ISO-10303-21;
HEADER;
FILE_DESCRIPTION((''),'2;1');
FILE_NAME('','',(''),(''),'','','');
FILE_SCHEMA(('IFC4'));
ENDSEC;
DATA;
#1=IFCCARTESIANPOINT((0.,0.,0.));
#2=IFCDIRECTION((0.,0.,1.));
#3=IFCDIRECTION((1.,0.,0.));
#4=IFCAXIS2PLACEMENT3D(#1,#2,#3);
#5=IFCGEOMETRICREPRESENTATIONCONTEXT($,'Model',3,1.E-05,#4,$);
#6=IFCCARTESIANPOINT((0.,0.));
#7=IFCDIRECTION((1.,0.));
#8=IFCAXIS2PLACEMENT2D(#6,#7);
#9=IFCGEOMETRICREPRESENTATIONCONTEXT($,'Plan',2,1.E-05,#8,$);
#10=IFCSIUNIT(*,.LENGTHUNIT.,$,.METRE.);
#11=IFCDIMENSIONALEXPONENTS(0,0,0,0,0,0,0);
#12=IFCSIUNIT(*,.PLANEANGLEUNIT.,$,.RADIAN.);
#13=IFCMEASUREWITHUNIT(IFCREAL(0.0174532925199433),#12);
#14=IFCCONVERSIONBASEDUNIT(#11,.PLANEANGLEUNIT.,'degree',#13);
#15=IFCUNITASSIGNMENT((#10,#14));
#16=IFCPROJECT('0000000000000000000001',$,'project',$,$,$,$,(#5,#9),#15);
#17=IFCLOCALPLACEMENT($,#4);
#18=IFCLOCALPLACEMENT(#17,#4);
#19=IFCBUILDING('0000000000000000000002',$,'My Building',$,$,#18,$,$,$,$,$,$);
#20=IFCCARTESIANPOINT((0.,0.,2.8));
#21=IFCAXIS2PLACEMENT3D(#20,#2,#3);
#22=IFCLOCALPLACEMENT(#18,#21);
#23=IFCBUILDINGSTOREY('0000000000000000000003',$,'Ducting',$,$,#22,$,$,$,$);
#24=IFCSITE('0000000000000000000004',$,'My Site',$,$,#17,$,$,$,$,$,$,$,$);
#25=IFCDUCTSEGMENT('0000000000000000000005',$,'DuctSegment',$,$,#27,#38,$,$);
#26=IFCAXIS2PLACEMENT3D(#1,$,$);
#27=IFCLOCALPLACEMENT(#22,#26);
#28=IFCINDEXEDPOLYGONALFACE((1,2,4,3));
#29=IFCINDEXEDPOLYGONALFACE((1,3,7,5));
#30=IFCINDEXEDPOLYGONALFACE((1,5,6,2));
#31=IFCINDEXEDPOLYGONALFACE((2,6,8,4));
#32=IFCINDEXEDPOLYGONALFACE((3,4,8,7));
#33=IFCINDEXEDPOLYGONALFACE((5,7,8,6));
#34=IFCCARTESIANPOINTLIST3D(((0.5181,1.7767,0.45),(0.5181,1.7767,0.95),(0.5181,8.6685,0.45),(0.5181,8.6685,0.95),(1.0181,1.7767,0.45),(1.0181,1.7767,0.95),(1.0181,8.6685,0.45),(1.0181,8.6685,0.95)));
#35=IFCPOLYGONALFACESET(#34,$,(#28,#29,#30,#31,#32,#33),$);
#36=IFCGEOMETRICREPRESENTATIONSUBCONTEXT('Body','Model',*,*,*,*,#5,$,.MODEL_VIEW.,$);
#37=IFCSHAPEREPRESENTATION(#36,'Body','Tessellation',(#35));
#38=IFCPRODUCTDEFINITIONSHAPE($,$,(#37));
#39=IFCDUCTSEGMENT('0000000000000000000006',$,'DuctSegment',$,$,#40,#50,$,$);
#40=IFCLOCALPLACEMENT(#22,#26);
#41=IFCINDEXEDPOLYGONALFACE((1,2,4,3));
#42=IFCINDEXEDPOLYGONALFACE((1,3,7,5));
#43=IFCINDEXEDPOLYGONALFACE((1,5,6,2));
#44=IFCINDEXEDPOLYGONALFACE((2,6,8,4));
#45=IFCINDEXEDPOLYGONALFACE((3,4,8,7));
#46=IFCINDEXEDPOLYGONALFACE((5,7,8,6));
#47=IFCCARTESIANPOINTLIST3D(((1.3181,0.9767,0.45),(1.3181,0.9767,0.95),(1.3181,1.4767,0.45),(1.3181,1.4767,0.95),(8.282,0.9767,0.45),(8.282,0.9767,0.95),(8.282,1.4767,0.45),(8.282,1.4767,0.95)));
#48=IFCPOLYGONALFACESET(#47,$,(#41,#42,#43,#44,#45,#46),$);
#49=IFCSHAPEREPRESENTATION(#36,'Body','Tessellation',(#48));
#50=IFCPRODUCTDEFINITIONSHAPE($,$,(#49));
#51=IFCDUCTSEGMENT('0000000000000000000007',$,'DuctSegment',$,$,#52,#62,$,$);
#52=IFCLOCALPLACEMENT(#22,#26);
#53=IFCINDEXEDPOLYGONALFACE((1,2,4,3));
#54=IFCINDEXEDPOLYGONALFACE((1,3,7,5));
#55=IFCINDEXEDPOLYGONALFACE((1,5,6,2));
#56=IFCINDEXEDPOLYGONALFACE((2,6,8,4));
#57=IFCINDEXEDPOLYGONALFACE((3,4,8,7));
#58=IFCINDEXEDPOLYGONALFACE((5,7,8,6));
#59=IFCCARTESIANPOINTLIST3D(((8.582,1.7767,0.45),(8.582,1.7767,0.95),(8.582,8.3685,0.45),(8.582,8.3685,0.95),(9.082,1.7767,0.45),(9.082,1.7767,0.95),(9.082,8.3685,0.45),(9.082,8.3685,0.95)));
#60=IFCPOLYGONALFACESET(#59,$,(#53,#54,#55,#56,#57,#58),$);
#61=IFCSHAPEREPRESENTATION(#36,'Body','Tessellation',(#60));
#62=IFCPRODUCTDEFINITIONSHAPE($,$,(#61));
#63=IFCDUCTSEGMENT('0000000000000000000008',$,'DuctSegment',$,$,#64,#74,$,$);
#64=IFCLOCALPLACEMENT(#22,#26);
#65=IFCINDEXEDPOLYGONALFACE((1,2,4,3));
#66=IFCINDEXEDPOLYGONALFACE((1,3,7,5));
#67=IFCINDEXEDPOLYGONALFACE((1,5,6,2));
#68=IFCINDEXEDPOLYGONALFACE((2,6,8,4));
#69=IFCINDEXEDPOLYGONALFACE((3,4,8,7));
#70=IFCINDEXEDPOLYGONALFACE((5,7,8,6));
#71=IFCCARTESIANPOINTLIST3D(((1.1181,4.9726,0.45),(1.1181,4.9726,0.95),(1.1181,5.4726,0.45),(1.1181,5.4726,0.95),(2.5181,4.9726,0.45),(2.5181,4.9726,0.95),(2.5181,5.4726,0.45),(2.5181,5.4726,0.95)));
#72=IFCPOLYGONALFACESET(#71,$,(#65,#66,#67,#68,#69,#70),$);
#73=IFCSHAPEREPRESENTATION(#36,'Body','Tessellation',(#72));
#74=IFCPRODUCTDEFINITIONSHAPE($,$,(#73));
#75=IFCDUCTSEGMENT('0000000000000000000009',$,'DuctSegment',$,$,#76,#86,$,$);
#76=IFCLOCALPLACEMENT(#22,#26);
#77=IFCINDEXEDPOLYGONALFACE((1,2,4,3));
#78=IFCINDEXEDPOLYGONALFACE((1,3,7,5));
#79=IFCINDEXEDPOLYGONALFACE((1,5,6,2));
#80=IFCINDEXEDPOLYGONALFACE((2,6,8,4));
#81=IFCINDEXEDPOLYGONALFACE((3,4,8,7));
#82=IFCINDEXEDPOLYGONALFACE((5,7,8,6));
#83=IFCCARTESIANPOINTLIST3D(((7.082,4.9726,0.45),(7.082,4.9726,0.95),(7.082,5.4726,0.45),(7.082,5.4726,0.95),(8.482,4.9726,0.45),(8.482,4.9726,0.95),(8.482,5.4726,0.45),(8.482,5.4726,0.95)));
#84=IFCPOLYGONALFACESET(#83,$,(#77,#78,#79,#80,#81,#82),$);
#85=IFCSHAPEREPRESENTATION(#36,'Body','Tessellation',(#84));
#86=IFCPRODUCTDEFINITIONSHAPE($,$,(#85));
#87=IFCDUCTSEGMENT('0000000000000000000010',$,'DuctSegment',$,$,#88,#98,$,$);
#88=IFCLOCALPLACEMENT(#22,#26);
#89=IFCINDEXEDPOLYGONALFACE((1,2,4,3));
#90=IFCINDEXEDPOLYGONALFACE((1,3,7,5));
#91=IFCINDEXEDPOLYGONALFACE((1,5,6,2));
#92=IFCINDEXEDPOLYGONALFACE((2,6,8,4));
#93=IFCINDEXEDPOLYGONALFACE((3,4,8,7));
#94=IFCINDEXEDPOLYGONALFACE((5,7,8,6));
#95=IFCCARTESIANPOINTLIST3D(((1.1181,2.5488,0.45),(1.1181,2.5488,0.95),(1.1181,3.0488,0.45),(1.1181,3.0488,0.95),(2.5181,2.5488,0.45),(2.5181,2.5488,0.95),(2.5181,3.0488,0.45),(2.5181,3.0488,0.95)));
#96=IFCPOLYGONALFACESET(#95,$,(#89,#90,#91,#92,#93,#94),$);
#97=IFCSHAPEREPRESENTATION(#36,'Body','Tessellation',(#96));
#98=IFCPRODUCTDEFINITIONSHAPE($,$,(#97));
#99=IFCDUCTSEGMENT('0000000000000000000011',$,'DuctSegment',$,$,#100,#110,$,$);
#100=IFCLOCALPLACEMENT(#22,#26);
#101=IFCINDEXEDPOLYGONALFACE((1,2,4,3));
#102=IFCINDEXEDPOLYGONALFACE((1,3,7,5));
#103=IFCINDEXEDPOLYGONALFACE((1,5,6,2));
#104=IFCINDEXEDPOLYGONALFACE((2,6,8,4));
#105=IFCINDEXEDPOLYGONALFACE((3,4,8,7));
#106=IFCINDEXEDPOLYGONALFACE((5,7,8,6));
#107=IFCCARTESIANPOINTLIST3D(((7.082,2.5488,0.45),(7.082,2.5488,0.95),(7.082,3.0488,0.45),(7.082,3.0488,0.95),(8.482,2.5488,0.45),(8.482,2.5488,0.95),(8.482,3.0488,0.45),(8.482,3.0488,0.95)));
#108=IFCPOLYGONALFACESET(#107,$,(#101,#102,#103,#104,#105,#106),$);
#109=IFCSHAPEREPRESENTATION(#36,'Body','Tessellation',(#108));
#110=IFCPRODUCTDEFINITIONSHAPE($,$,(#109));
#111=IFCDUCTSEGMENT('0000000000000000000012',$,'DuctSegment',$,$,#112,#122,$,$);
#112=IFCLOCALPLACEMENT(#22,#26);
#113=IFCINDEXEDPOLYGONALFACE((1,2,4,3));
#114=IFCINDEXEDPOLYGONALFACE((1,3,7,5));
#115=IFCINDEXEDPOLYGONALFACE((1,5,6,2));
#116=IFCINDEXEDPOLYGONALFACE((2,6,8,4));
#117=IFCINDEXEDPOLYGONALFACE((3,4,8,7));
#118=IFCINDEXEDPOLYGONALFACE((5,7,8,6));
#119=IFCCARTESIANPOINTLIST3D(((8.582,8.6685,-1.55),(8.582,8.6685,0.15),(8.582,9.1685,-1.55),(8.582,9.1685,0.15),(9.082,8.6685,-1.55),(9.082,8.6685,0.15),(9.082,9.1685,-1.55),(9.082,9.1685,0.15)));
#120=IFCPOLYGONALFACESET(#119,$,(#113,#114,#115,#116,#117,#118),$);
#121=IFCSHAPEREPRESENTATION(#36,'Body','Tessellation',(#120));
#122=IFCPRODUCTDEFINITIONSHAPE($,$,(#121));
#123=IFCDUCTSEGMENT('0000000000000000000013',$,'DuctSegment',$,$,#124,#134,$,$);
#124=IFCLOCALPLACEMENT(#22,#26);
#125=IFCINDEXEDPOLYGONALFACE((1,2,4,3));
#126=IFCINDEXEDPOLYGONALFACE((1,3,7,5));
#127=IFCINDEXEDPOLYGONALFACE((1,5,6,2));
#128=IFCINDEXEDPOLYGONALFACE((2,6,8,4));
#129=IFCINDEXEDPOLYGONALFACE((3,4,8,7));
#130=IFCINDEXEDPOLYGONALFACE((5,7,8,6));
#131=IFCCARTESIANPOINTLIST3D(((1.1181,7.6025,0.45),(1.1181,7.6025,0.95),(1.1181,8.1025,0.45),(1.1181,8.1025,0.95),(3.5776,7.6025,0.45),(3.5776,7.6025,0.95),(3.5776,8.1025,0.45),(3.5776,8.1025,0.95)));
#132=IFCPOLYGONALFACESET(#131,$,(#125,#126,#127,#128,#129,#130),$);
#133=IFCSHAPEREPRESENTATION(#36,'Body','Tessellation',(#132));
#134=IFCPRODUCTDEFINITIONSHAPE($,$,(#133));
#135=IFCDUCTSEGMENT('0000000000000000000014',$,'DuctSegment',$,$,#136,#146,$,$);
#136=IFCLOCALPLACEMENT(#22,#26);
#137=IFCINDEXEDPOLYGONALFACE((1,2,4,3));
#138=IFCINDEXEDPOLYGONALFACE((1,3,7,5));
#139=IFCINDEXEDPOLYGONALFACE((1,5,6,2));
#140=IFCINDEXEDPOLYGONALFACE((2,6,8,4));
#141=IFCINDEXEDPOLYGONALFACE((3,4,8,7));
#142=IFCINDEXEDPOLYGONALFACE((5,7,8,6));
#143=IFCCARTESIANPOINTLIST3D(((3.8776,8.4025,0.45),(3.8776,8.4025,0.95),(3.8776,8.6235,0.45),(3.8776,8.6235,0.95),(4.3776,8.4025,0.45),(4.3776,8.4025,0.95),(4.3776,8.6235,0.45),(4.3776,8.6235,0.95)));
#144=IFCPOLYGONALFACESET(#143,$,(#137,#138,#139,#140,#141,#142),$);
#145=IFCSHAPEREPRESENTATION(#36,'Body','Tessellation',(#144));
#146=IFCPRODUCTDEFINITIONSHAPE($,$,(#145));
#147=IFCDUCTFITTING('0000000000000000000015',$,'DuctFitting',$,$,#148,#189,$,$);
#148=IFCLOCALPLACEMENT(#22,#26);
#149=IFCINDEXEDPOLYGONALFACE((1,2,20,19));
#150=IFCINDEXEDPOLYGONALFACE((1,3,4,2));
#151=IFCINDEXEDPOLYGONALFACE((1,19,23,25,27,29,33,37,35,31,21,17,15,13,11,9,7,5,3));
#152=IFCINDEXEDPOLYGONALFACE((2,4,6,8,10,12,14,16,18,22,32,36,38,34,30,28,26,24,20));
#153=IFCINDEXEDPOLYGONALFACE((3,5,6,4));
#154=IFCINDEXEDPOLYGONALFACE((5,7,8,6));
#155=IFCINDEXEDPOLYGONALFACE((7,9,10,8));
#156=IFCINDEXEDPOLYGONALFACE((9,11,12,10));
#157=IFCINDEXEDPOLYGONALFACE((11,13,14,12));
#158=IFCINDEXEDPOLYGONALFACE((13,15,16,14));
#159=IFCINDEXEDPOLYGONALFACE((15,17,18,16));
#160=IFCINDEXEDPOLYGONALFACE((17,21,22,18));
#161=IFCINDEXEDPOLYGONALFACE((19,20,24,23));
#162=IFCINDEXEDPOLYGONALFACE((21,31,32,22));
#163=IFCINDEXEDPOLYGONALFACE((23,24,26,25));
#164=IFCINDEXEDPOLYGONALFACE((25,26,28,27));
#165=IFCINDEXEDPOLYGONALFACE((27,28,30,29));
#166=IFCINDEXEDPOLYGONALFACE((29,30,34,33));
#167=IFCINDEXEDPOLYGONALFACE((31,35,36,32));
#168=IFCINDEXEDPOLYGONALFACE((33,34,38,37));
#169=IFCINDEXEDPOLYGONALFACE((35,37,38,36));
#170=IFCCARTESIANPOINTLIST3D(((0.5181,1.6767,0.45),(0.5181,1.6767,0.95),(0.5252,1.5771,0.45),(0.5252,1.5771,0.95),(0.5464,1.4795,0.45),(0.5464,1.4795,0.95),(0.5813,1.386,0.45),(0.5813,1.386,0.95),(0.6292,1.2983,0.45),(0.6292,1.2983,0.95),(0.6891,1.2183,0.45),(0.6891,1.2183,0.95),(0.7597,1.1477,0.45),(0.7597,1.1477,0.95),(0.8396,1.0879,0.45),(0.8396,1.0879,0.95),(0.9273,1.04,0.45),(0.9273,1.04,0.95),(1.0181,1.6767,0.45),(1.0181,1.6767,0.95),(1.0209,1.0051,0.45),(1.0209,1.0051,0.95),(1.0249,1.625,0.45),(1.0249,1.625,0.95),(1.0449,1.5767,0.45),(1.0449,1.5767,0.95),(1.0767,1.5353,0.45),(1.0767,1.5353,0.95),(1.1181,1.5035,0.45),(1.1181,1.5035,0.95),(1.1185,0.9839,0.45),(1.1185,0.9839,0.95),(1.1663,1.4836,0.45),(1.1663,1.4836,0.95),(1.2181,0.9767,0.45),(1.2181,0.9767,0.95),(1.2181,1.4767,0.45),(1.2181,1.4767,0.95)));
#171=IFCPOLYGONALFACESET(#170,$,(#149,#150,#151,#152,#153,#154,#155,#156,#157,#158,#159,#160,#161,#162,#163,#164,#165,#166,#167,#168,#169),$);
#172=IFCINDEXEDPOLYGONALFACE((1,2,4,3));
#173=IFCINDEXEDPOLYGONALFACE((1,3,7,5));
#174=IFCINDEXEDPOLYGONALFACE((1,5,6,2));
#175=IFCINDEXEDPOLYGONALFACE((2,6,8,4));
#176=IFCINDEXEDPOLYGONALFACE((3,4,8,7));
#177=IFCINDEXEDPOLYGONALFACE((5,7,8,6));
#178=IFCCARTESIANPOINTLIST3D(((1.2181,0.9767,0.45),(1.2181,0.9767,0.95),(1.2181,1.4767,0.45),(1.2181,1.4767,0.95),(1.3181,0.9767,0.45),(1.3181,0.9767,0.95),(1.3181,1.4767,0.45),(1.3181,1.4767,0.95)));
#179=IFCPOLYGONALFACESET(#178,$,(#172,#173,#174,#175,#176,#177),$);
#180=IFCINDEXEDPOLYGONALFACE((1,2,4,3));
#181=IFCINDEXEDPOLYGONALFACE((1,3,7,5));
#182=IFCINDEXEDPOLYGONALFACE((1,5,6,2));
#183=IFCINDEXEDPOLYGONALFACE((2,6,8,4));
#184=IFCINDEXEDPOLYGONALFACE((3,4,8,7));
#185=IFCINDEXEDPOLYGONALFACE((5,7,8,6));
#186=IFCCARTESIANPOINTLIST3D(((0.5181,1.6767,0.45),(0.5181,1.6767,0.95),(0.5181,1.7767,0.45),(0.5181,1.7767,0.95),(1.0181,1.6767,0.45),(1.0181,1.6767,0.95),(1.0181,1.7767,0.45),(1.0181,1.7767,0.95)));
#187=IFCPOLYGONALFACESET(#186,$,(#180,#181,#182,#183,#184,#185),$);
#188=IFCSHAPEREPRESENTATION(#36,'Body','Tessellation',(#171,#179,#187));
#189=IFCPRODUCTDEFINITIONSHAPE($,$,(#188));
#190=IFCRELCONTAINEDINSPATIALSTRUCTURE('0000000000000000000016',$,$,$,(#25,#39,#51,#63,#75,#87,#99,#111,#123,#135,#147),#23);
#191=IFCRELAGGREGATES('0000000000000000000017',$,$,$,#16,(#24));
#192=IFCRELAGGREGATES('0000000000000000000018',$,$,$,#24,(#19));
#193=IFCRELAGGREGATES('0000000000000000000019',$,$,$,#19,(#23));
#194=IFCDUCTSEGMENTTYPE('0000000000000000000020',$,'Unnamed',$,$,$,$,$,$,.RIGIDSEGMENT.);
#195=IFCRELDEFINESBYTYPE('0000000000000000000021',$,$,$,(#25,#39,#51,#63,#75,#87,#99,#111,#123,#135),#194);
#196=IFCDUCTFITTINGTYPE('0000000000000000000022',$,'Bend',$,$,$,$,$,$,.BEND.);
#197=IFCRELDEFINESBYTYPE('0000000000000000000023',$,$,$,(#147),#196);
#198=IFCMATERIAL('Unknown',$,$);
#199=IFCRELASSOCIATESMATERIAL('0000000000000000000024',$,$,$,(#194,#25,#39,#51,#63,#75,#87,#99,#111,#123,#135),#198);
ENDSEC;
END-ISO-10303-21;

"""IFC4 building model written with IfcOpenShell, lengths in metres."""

from ifc_helpers import new_model, entity, si_unit, converted_unit, frame, origin_with_axes, origin_2d_with_axis, place, context, subcontext, project, spatial, line, arc, indexed_curve, rectangle, outline, extrude, source, transform, mapped, material, material_profile, profile_set, profile_usage, type_object, type_shapes, element, save


model = new_model("IFC4")

# Units and contexts
model_context = context("Model", 3, precision=1e-05, world=origin_with_axes())
plan_context = context("Plan", 2, precision=1e-05, world=origin_2d_with_axis())
body_context = subcontext(model_context, "Body", "Model", "MODEL_VIEW")
ifc_project = project(units=[si_unit("LENGTHUNIT", "METRE"), converted_unit("PLANEANGLEUNIT", "degree", entity("IfcReal", 0.0174532925199433), si_unit("PLANEANGLEUNIT", "RADIAN"), dimensions=[0, 0, 0, 0, 0, 0, 0])], contexts=[model_context, plan_context])

# Site, building, storey
site_placement = place(None, origin_with_axes())
site = spatial("IfcSite", under=ifc_project, at=site_placement, Name="My Site")
building_placement = place(site_placement, origin_with_axes())
building = spatial("IfcBuilding", under=site, at=building_placement, Name="My Building")
storey_placement = place(building_placement, frame((0.0, 0.0, 2.8), z_axis=(0.0, 0.0, 1.0), x_axis=(1.0, 0.0, 0.0)))
storey = spatial("IfcBuildingStorey", under=building, at=storey_placement, Name="Ducting")

# Duct segments
ifc_material = material(Name="Unknown")
ifc_material_profile_1 = material_profile(ifc_material, rectangle(XDim=0.5, YDim=0.5))
ifc_profile_set_1 = profile_set([ifc_material_profile_1])
ifc_profile_usage_1 = profile_usage(ifc_profile_set_1, cardinal=5)
duct_segment_type = type_object("IfcDuctSegmentType", Name="Unnamed", PredefinedType="RIGIDSEGMENT", material=ifc_profile_set_1)
duct_segment_1_placement = place(storey_placement, frame((0.7681, 8.6685, 0.7), z_axis=(0.0, -1.0, 0.0), x_axis=(1.0, 0.0, 0.0)))
element("IfcDuctSegment", 1, at=duct_segment_1_placement, inside=storey, type_object=duct_segment_type, material=ifc_profile_usage_1, Name="DuctSegment", context=body_context, shape_type="SweptSolid", body=[
    extrude(rectangle(XDim=0.5, YDim=0.5), origin_with_axes(), (0.0, 0.0, 1.0), 6.8918),
])
ifc_profile_usage_2 = profile_usage(ifc_profile_set_1, cardinal=5)
duct_segment_2_placement = place(storey_placement, frame((1.3181, 1.2267, 0.7), z_axis=(1.0, 0.0, 0.0), x_axis=(0.0, 1.0, 0.0)))
element("IfcDuctSegment", 2, at=duct_segment_2_placement, inside=storey, type_object=duct_segment_type, material=ifc_profile_usage_2, Name="DuctSegment", context=body_context, shape_type="SweptSolid", body=[
    extrude(rectangle(XDim=0.5, YDim=0.5), origin_with_axes(), (0.0, 0.0, 1.0), 6.964),
])
ifc_profile_usage_3 = profile_usage(ifc_profile_set_1, cardinal=5)
duct_segment_3_placement = place(storey_placement, frame((8.832, 8.3685, 0.7), z_axis=(0.0, -1.0, 0.0), x_axis=(1.0, 0.0, 0.0)))
element("IfcDuctSegment", 3, at=duct_segment_3_placement, inside=storey, type_object=duct_segment_type, material=ifc_profile_usage_3, Name="DuctSegment", context=body_context, shape_type="SweptSolid", body=[
    extrude(rectangle(XDim=0.5, YDim=0.5), origin_with_axes(), (0.0, 0.0, 1.0), 6.5918),
])
ifc_profile_usage_4 = profile_usage(ifc_profile_set_1, cardinal=5)
duct_segment_4_placement = place(storey_placement, frame((1.1181, 5.2226, 0.7), z_axis=(1.0, 0.0, 0.0), x_axis=(0.0, 1.0, 0.0)))
element("IfcDuctSegment", 4, at=duct_segment_4_placement, inside=storey, type_object=duct_segment_type, material=ifc_profile_usage_4, Name="DuctSegment", context=body_context, shape_type="SweptSolid", body=[
    extrude(rectangle(XDim=0.5, YDim=0.5), origin_with_axes(), (0.0, 0.0, 1.0), 1.4),
])
ifc_profile_usage_5 = profile_usage(ifc_profile_set_1, cardinal=5)
duct_segment_5_placement = place(storey_placement, frame((8.482, 5.2226, 0.7), z_axis=(-1.0, 0.0, 0.0), x_axis=(0.0, -1.0, 0.0)))
element("IfcDuctSegment", 5, at=duct_segment_5_placement, inside=storey, type_object=duct_segment_type, material=ifc_profile_usage_5, Name="DuctSegment", context=body_context, shape_type="SweptSolid", body=[
    extrude(rectangle(XDim=0.5, YDim=0.5), origin_with_axes(), (0.0, 0.0, 1.0), 1.4),
])
ifc_profile_usage_6 = profile_usage(ifc_profile_set_1, cardinal=5)
duct_segment_6_placement = place(storey_placement, frame((1.1181, 2.7988, 0.7), z_axis=(1.0, 0.0, 0.0), x_axis=(0.0, 1.0, 0.0)))
element("IfcDuctSegment", 6, at=duct_segment_6_placement, inside=storey, type_object=duct_segment_type, material=ifc_profile_usage_6, Name="DuctSegment", context=body_context, shape_type="SweptSolid", body=[
    extrude(rectangle(XDim=0.5, YDim=0.5), origin_with_axes(), (0.0, 0.0, 1.0), 1.4),
])
ifc_profile_usage_7 = profile_usage(ifc_profile_set_1, cardinal=5)
duct_segment_7_placement = place(storey_placement, frame((8.482, 2.7988, 0.7), z_axis=(-1.0, 0.0, 0.0), x_axis=(0.0, -1.0, 0.0)))
element("IfcDuctSegment", 7, at=duct_segment_7_placement, inside=storey, type_object=duct_segment_type, material=ifc_profile_usage_7, Name="DuctSegment", context=body_context, shape_type="SweptSolid", body=[
    extrude(rectangle(XDim=0.5, YDim=0.5), origin_with_axes(), (0.0, 0.0, 1.0), 1.4),
])
ifc_profile_usage_8 = profile_usage(ifc_profile_set_1, cardinal=5)
duct_segment_8_placement = place(storey_placement, frame((8.832, 8.9185, 0.15), z_axis=(0.0, 0.0, -1.0), x_axis=(-1.0, 0.0, 0.0)))
element("IfcDuctSegment", 8, at=duct_segment_8_placement, inside=storey, type_object=duct_segment_type, material=ifc_profile_usage_8, Name="DuctSegment", context=body_context, shape_type="SweptSolid", body=[
    extrude(rectangle(XDim=0.5, YDim=0.5), origin_with_axes(), (0.0, 0.0, 1.0), 1.7),
])
ifc_profile_usage_9 = profile_usage(ifc_profile_set_1, cardinal=5)
duct_segment_9_placement = place(storey_placement, frame((3.5776, 7.8525, 0.7), z_axis=(-1.0, 0.0, 0.000001), x_axis=(0.0, -1.0, 0.0)))
element("IfcDuctSegment", 9, at=duct_segment_9_placement, inside=storey, type_object=duct_segment_type, material=ifc_profile_usage_9, Name="DuctSegment", context=body_context, shape_type="SweptSolid", body=[
    extrude(rectangle(XDim=0.5, YDim=0.5), origin_with_axes(), (0.0, 0.0, 1.0), 2.4595),
])
ifc_profile_usage_10 = profile_usage(ifc_profile_set_1, cardinal=5)
duct_segment_10_placement = place(storey_placement, frame((4.1276, 8.4025, 0.7), z_axis=(0.0, 1.0, 0.0), x_axis=(-1.0, 0.0, 0.0)))
element("IfcDuctSegment", 10, at=duct_segment_10_placement, inside=storey, type_object=duct_segment_type, material=ifc_profile_usage_10, Name="DuctSegment", context=body_context, shape_type="SweptSolid", body=[
    extrude(rectangle(XDim=0.5, YDim=0.5), origin_with_axes(), (0.0, 0.0, 1.0), 0.221),
])

# Duct fitting
duct_fitting_type_1 = type_object("IfcDuctFittingType", Name="Bend", PredefinedType="BEND")
shared_shape = source(origin_with_axes(), body_context, "Body", "SweptSolid", [
    extrude(outline(indexed_curve([(0.25, 0.0), (0.3086, -0.1414), (0.45, -0.2), (0.45, -0.7), (-0.045, -0.495), (-0.25, 0.0)], segments=[arc(1, 2, 3), line(3, 4), arc(4, 5, 6), line(6, 1)])), frame((0.0, -0.25, -0.1), z_axis=(0.0, -1.0, 0.0), x_axis=(1.0, 0.0, 0.0)), (0.0, 0.0, -1.0), 0.5),
    extrude(rectangle(XDim=0.5, YDim=0.5), origin_with_axes(), (0.0, 0.0, -1.0), 0.1),
    extrude(rectangle(XDim=0.5, YDim=0.5), frame((0.45, 0.0, -0.55), z_axis=(1.0, 0.0, 0.0), x_axis=(0.0, 0.0, 1.0)), (0.0, 0.0, 1.0), 0.1),
])
type_shapes(duct_fitting_type_1, [shared_shape])
for number, where, z_axis, x_axis, name in (
    (11, (1.3181, 1.2267, 0.7), (1.0, 0.0, 0.0), (0.0, 1.0, 0.0), "DuctFitting"),
):
    element("IfcDuctFitting", number, at=place(storey_placement, frame(where, z_axis=z_axis, x_axis=x_axis)), inside=storey, type_object=duct_fitting_type_1, Name=name, context=body_context, shape_type="MappedRepresentation", body=[
        mapped(shared_shape, transform((0.0, 0.0, 0.0), x_axis=(1.0, 0.0, 0.0), y_axis=(0.0, 1.0, 0.0), z_axis=(0.0, 0.0, 1.0), scale=1.0)),
    ])

save(model, "model.ifc")
